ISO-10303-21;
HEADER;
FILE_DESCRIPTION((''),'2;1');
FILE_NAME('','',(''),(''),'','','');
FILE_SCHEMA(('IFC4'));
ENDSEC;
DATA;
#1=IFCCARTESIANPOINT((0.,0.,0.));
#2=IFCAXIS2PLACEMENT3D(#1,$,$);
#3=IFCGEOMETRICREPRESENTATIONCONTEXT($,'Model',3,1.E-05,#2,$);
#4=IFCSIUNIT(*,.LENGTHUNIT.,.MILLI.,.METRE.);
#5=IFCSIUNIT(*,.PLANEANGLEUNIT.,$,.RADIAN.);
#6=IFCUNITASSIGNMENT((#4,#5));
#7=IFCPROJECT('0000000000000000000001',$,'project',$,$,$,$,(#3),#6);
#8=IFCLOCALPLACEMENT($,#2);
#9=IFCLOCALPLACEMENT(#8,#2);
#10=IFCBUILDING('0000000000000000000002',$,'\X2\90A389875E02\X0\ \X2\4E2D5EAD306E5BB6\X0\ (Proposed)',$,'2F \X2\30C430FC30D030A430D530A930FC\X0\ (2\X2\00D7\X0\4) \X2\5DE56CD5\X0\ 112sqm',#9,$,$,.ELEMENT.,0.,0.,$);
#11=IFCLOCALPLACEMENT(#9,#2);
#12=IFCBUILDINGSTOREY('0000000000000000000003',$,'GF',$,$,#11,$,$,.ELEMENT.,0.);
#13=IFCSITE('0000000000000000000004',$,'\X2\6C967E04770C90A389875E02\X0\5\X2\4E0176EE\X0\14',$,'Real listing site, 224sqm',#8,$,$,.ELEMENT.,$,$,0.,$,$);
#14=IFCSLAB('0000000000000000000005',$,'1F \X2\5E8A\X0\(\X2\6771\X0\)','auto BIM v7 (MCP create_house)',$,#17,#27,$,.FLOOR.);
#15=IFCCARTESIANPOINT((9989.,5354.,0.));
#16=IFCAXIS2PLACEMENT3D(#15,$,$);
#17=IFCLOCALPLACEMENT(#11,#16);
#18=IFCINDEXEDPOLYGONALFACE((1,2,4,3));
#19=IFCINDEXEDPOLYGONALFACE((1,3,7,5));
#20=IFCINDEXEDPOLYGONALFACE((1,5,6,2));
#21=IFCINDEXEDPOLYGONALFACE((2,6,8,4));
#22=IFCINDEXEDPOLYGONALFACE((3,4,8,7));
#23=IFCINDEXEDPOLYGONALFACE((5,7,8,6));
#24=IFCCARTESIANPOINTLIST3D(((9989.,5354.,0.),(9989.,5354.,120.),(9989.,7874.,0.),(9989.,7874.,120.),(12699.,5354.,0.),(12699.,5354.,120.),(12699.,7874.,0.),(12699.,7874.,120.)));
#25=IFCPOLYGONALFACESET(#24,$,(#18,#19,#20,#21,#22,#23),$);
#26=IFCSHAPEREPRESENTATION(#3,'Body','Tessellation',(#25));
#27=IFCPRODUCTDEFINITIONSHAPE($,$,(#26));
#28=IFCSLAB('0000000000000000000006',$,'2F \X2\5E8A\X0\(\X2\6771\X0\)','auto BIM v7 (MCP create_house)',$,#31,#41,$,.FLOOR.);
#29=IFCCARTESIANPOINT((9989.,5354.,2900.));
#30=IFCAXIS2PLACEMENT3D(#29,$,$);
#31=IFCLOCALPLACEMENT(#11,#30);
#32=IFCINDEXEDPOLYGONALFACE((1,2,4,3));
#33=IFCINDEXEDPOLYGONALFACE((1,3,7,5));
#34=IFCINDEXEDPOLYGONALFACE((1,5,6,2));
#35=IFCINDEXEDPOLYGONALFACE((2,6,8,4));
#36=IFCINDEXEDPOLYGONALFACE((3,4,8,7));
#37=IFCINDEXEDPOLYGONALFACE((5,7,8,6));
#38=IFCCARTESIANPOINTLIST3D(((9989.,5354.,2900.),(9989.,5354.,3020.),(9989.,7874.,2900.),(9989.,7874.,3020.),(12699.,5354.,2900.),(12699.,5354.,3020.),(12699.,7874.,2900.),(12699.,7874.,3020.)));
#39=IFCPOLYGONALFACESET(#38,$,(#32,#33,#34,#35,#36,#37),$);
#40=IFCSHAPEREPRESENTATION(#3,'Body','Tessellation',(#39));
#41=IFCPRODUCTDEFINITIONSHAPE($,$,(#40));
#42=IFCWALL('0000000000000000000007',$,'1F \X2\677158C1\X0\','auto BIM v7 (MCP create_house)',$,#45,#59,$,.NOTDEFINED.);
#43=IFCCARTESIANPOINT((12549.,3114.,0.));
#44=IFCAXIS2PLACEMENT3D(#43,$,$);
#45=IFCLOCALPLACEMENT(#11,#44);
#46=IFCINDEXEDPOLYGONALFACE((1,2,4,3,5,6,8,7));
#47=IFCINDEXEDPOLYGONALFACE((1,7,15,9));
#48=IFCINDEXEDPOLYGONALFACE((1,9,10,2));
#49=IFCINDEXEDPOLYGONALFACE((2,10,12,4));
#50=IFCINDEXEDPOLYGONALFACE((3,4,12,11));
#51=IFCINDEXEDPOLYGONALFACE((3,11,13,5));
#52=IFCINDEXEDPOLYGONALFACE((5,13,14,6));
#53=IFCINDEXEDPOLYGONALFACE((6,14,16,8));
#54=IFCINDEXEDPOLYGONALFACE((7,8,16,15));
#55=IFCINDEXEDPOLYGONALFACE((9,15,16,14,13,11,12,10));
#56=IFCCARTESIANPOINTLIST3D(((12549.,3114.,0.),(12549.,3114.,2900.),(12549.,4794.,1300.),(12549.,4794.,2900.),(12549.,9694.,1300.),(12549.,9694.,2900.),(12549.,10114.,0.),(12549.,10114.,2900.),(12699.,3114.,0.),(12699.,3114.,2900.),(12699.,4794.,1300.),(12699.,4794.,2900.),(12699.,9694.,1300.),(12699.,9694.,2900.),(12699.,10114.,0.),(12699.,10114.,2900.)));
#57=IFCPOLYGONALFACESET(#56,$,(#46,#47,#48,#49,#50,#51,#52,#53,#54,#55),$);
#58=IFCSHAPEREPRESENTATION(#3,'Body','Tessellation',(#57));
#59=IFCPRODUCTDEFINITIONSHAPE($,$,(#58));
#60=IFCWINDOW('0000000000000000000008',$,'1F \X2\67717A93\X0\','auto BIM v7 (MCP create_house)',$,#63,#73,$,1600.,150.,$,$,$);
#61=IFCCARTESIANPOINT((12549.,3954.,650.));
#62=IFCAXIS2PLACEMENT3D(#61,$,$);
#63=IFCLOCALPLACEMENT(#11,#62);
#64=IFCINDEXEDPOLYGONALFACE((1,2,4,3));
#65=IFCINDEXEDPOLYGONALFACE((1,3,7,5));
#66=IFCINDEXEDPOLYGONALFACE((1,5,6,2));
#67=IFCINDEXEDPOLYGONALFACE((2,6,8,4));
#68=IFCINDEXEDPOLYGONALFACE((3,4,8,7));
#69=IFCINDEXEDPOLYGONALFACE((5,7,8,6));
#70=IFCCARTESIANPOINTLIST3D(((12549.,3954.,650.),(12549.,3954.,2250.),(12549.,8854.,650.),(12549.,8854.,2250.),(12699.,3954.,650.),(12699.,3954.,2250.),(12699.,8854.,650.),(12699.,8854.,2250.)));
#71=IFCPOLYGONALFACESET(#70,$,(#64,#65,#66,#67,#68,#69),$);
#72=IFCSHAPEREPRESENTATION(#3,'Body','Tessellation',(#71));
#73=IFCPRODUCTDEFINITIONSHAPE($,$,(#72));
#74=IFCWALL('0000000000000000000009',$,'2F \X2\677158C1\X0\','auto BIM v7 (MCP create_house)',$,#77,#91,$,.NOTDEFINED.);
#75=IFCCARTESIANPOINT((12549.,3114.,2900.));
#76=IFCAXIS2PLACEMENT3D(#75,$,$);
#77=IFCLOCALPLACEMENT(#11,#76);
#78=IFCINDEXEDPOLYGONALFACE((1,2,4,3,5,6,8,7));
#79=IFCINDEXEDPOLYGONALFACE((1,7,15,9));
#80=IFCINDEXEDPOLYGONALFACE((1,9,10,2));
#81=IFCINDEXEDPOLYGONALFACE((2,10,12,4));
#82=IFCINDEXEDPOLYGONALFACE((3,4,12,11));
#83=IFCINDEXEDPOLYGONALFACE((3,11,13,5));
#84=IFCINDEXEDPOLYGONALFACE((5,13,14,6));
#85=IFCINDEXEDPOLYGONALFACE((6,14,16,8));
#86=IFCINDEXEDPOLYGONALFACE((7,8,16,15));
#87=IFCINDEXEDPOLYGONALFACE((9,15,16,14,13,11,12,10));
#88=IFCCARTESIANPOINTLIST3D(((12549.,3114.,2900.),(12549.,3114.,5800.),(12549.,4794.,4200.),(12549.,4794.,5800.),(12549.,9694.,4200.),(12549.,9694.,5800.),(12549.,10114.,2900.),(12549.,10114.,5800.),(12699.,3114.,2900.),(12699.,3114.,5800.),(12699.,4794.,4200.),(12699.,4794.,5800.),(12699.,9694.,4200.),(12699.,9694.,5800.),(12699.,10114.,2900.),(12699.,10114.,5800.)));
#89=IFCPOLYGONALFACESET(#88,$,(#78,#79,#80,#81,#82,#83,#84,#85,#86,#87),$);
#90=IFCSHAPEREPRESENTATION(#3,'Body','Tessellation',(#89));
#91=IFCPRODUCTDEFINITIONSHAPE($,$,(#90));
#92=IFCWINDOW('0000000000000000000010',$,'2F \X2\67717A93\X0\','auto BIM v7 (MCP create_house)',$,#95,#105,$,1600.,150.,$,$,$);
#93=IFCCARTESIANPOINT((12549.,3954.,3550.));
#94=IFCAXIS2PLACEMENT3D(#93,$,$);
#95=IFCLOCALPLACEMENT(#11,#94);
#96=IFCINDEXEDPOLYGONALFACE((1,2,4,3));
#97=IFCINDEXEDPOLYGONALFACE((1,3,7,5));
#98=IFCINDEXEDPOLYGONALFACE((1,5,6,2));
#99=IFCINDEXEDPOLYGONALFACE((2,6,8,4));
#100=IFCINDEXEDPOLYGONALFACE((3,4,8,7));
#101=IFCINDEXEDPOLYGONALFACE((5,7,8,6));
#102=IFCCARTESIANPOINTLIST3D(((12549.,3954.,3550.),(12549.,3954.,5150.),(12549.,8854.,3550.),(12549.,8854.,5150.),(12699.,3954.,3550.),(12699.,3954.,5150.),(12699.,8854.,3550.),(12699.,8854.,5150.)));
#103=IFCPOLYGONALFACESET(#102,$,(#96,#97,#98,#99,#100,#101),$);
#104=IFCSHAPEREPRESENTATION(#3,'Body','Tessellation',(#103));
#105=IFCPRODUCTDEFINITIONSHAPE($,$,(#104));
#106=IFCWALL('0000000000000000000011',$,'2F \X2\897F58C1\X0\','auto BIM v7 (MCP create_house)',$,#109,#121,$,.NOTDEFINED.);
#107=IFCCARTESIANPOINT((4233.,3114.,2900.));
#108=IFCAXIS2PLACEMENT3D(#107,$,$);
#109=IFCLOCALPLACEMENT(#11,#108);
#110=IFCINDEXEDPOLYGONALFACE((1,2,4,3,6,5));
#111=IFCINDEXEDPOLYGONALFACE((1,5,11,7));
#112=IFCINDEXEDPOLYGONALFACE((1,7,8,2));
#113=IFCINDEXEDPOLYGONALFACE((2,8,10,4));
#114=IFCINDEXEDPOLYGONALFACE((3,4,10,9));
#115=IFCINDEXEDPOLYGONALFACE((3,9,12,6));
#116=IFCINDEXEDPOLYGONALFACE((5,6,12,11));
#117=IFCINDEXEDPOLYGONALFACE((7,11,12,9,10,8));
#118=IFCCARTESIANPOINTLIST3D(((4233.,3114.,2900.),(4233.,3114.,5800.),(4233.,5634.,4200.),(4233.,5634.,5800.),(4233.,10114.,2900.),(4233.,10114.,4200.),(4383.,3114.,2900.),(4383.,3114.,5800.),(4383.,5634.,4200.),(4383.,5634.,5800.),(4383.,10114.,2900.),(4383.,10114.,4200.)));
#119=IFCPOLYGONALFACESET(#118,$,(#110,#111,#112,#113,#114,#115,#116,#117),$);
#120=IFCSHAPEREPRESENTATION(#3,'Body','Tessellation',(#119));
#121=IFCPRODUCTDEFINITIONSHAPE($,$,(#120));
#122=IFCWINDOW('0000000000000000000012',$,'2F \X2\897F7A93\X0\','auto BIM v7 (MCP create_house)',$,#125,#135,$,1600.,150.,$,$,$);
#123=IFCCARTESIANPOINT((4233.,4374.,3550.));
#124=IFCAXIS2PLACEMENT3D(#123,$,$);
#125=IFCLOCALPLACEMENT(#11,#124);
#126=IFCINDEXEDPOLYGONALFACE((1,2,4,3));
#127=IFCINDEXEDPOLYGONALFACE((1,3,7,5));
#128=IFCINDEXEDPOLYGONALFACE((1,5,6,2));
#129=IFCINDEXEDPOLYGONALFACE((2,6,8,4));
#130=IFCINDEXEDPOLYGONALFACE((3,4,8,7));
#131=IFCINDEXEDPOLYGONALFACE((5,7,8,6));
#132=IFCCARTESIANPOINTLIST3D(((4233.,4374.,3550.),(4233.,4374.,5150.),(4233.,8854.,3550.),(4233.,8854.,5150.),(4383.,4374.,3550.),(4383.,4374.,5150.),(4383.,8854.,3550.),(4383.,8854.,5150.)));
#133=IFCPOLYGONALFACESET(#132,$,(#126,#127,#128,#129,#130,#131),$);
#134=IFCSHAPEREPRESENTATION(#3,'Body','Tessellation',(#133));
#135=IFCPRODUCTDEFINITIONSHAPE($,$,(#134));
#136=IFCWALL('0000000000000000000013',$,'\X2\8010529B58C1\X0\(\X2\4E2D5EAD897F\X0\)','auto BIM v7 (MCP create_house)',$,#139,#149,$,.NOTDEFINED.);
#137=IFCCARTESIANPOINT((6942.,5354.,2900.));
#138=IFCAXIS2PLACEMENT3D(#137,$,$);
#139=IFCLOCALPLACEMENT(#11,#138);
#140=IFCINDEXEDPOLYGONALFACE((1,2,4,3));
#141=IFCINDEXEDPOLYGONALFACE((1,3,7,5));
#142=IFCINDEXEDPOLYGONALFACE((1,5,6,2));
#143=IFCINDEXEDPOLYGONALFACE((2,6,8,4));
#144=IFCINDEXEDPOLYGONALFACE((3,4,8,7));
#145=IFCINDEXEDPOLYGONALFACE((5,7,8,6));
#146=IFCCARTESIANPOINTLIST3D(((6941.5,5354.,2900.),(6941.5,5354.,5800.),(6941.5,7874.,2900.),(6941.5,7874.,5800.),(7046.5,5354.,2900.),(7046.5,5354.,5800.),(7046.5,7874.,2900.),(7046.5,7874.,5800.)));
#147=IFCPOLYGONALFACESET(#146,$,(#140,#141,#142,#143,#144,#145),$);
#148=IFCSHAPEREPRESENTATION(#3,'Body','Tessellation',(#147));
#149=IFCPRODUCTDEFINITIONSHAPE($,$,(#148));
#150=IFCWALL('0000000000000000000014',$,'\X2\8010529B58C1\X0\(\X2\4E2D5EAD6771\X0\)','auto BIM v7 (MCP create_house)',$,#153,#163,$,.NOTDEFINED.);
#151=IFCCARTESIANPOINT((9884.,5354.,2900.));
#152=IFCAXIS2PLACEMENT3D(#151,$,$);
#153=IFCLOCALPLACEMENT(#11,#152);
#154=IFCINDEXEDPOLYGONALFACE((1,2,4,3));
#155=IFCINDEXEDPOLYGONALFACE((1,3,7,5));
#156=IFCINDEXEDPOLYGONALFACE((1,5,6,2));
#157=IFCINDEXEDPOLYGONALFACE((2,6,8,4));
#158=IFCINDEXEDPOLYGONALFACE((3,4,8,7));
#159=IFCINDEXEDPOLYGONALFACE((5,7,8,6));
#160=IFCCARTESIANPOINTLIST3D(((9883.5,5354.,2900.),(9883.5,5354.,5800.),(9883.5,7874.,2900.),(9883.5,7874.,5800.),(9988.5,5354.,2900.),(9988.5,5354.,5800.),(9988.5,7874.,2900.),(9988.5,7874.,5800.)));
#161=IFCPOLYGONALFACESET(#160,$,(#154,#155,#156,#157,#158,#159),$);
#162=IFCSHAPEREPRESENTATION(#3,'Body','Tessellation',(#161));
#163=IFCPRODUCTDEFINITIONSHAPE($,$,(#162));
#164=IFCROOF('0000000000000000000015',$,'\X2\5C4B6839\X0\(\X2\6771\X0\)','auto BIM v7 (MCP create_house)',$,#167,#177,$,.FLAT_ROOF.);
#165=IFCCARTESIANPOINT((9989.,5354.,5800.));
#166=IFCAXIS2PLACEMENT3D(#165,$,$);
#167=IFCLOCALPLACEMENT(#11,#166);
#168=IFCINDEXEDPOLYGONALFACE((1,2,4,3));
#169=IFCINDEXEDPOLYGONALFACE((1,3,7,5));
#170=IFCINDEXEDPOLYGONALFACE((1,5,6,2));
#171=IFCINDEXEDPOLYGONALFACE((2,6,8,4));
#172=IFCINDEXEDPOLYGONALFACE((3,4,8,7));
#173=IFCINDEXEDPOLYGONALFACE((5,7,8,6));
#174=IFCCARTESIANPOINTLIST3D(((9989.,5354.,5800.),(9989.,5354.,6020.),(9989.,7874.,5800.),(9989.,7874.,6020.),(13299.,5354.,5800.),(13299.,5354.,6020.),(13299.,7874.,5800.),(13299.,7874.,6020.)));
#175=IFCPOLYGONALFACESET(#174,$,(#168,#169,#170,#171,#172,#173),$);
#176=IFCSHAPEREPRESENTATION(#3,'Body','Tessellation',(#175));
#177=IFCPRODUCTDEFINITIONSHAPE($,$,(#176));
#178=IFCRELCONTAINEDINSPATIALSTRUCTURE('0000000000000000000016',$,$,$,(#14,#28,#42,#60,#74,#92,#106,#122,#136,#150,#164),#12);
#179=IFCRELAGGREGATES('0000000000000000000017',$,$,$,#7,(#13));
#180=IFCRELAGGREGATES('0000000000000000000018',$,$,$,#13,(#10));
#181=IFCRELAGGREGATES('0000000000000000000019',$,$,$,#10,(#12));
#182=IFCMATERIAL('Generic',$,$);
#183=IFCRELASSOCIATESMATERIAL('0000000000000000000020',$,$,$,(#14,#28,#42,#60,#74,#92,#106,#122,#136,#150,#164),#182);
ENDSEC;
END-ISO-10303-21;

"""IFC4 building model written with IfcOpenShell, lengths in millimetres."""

from ifc_helpers import new_model, si_unit, frame, frame_2d, origin, place, context, project, spatial, rectangle, extrude, material, element, fill, save


model = new_model("IFC4")

# Units and contexts
model_context = context("Model", 3, precision=1e-05, world=origin())
ifc_project = project(units=[si_unit("LENGTHUNIT", "METRE", prefix="MILLI"), si_unit("PLANEANGLEUNIT", "RADIAN")], contexts=[model_context])

# Site, building, storey
site_placement = place(None, origin())
site = spatial("IfcSite", under=ifc_project, at=site_placement, Name="沖縄県那覇市5丁目14", ObjectType="Real listing site, 224sqm", CompositionType="ELEMENT", RefElevation=0.0)
building_placement = place(site_placement, origin())
building = spatial("IfcBuilding", under=site, at=building_placement, Name="那覇市 中庭の家 (Proposed)", ObjectType="2F ツーバイフォー (2×4) 工法 112sqm", CompositionType="ELEMENT", ElevationOfRefHeight=0.0, ElevationOfTerrain=0.0)
storey_placement = place(building_placement, origin())
storey = spatial("IfcBuildingStorey", under=building, at=storey_placement, Name="GF", CompositionType="ELEMENT", Elevation=0.0)

# Slabs
ifc_material = material(Name="Generic")
slab_1_placement = place(storey_placement, frame((9989.0, 5354.0, 0.0)))
element("IfcSlab", 1, at=slab_1_placement, inside=storey, material=ifc_material, Name="1F 床(東)", Description="auto BIM v7 (MCP create_house)", PredefinedType="FLOOR", context=model_context, shape_type="SweptSolid", body=[
    extrude(rectangle(XDim=2710.0, YDim=2520.0, at=frame_2d((1355.0, 1260.0))), frame((9989.0, 5354.0, 0.0)), (0.0, 0.0, 1.0), 120.0),
])
slab_2_placement = place(storey_placement, frame((9989.0, 5354.0, 2900.0)))
element("IfcSlab", 2, at=slab_2_placement, inside=storey, material=ifc_material, Name="2F 床(東)", Description="auto BIM v7 (MCP create_house)", PredefinedType="FLOOR", context=model_context, shape_type="SweptSolid", body=[
    extrude(rectangle(XDim=2710.0, YDim=2520.0, at=frame_2d((1355.0, 1260.0))), frame((9989.0, 5354.0, 2900.0)), (0.0, 0.0, 1.0), 120.0),
])

# Wall, opening, window
wall_1_placement = place(storey_placement, frame((12549.0, 3114.0, 0.0)))
wall_1 = element("IfcWall", 3, at=wall_1_placement, inside=storey, material=ifc_material, Name="1F 東壁", Description="auto BIM v7 (MCP create_house)", PredefinedType="NOTDEFINED", context=model_context, shape_type="SweptSolid", body=[
    extrude(rectangle(XDim=150.0, YDim=7000.0, at=frame_2d((75.0, 3500.0))), frame((12549.0, 3114.0, 0.0)), (0.0, 0.0, 1.0), 2900.0),
])
opening_1_placement = place(storey_placement, frame((12549.0, 3954.0, 650.0)))
opening_1 = element("IfcOpeningElement", 4, at=opening_1_placement, cuts=wall_1, PredefinedType="NOTDEFINED", context=model_context, shape_type="SweptSolid", body=[
    extrude(rectangle(XDim=150.0, YDim=4900.0, at=frame_2d((75.0, 2450.0))), frame((12549.0, 3954.0, 650.0)), (0.0, 0.0, 1.0), 1600.0),
])
window_1_placement = place(storey_placement, frame((12549.0, 3954.0, 650.0)))
window_1 = element("IfcWindow", 5, at=window_1_placement, inside=storey, material=ifc_material, Name="1F 東窓", Description="auto BIM v7 (MCP create_house)", OverallHeight=1600.0, OverallWidth=150.0, context=model_context, shape_type="SweptSolid", body=[
    extrude(rectangle(XDim=150.0, YDim=4900.0, at=frame_2d((75.0, 2450.0))), frame((12549.0, 3954.0, 650.0)), (0.0, 0.0, 1.0), 1600.0),
])
fill(opening_1, window_1)

# Walls, openings, windows
wall_2_placement = place(storey_placement, frame((12549.0, 3114.0, 2900.0)))
wall_2 = element("IfcWall", 6, at=wall_2_placement, inside=storey, material=ifc_material, Name="2F 東壁", Description="auto BIM v7 (MCP create_house)", PredefinedType="NOTDEFINED", context=model_context, shape_type="SweptSolid", body=[
    extrude(rectangle(XDim=150.0, YDim=7000.0, at=frame_2d((75.0, 3500.0))), frame((12549.0, 3114.0, 2900.0)), (0.0, 0.0, 1.0), 2900.0),
])
opening_2_placement = place(storey_placement, frame((12549.0, 3954.0, 3550.0)))
opening_2 = element("IfcOpeningElement", 7, at=opening_2_placement, cuts=wall_2, PredefinedType="NOTDEFINED", context=model_context, shape_type="SweptSolid", body=[
    extrude(rectangle(XDim=150.0, YDim=4900.0, at=frame_2d((75.0, 2450.0))), frame((12549.0, 3954.0, 3550.0)), (0.0, 0.0, 1.0), 1600.0),
])
window_2_placement = place(storey_placement, frame((12549.0, 3954.0, 3550.0)))
window_2 = element("IfcWindow", 8, at=window_2_placement, inside=storey, material=ifc_material, Name="2F 東窓", Description="auto BIM v7 (MCP create_house)", OverallHeight=1600.0, OverallWidth=150.0, context=model_context, shape_type="SweptSolid", body=[
    extrude(rectangle(XDim=150.0, YDim=4900.0, at=frame_2d((75.0, 2450.0))), frame((12549.0, 3954.0, 3550.0)), (0.0, 0.0, 1.0), 1600.0),
])
fill(opening_2, window_2)
wall_3_placement = place(storey_placement, frame((4233.0, 3114.0, 2900.0)))
wall_3 = element("IfcWall", 9, at=wall_3_placement, inside=storey, material=ifc_material, Name="2F 西壁", Description="auto BIM v7 (MCP create_house)", PredefinedType="NOTDEFINED", context=model_context, shape_type="SweptSolid", body=[
    extrude(rectangle(XDim=150.0, YDim=7000.0, at=frame_2d((75.0, 3500.0))), frame((4233.0, 3114.0, 2900.0)), (0.0, 0.0, 1.0), 2900.0),
])
opening_3_placement = place(storey_placement, frame((4233.0, 4374.0, 3550.0)))
opening_3 = element("IfcOpeningElement", 10, at=opening_3_placement, cuts=wall_3, PredefinedType="NOTDEFINED", context=model_context, shape_type="SweptSolid", body=[
    extrude(rectangle(XDim=150.0, YDim=4480.0, at=frame_2d((75.0, 2240.0))), frame((4233.0, 4374.0, 3550.0)), (0.0, 0.0, 1.0), 1600.0),
])
window_3_placement = place(storey_placement, frame((4233.0, 4374.0, 3550.0)))
window_3 = element("IfcWindow", 11, at=window_3_placement, inside=storey, material=ifc_material, Name="2F 西窓", Description="auto BIM v7 (MCP create_house)", OverallHeight=1600.0, OverallWidth=150.0, context=model_context, shape_type="SweptSolid", body=[
    extrude(rectangle(XDim=150.0, YDim=4480.0, at=frame_2d((75.0, 2240.0))), frame((4233.0, 4374.0, 3550.0)), (0.0, 0.0, 1.0), 1600.0),
])
fill(opening_3, window_3)

# Walls
wall_4_placement = place(storey_placement, frame((6942.0, 5354.0, 2900.0)))
element("IfcWall", 12, at=wall_4_placement, inside=storey, material=ifc_material, Name="耐力壁(中庭西)", Description="auto BIM v7 (MCP create_house)", PredefinedType="NOTDEFINED", context=model_context, shape_type="SweptSolid", body=[
    extrude(rectangle(XDim=105.0, YDim=2520.0, at=frame_2d((52.0, 1260.0))), frame((6942.0, 5354.0, 2900.0)), (0.0, 0.0, 1.0), 2900.0),
])
wall_5_placement = place(storey_placement, frame((9884.0, 5354.0, 2900.0)))
element("IfcWall", 13, at=wall_5_placement, inside=storey, material=ifc_material, Name="耐力壁(中庭東)", Description="auto BIM v7 (MCP create_house)", PredefinedType="NOTDEFINED", context=model_context, shape_type="SweptSolid", body=[
    extrude(rectangle(XDim=105.0, YDim=2520.0, at=frame_2d((52.0, 1260.0))), frame((9884.0, 5354.0, 2900.0)), (0.0, 0.0, 1.0), 2900.0),
])

# Roof
for number, where, name in (
    (14, (9989.0, 5354.0, 5800.0), "屋根(東)"),
):
    element("IfcRoof", number, at=place(storey_placement, frame(where)), inside=storey, material=ifc_material, Name=name, Description="auto BIM v7 (MCP create_house)", PredefinedType="FLAT_ROOF", context=model_context, shape_type="SweptSolid", body=[
        extrude(rectangle(XDim=3310.0, YDim=2520.0, at=frame_2d((1655.0, 1260.0))), frame((9989.0, 5354.0, 5800.0)), (0.0, 0.0, 1.0), 220.0),
    ])

save(model, "model.ifc")
